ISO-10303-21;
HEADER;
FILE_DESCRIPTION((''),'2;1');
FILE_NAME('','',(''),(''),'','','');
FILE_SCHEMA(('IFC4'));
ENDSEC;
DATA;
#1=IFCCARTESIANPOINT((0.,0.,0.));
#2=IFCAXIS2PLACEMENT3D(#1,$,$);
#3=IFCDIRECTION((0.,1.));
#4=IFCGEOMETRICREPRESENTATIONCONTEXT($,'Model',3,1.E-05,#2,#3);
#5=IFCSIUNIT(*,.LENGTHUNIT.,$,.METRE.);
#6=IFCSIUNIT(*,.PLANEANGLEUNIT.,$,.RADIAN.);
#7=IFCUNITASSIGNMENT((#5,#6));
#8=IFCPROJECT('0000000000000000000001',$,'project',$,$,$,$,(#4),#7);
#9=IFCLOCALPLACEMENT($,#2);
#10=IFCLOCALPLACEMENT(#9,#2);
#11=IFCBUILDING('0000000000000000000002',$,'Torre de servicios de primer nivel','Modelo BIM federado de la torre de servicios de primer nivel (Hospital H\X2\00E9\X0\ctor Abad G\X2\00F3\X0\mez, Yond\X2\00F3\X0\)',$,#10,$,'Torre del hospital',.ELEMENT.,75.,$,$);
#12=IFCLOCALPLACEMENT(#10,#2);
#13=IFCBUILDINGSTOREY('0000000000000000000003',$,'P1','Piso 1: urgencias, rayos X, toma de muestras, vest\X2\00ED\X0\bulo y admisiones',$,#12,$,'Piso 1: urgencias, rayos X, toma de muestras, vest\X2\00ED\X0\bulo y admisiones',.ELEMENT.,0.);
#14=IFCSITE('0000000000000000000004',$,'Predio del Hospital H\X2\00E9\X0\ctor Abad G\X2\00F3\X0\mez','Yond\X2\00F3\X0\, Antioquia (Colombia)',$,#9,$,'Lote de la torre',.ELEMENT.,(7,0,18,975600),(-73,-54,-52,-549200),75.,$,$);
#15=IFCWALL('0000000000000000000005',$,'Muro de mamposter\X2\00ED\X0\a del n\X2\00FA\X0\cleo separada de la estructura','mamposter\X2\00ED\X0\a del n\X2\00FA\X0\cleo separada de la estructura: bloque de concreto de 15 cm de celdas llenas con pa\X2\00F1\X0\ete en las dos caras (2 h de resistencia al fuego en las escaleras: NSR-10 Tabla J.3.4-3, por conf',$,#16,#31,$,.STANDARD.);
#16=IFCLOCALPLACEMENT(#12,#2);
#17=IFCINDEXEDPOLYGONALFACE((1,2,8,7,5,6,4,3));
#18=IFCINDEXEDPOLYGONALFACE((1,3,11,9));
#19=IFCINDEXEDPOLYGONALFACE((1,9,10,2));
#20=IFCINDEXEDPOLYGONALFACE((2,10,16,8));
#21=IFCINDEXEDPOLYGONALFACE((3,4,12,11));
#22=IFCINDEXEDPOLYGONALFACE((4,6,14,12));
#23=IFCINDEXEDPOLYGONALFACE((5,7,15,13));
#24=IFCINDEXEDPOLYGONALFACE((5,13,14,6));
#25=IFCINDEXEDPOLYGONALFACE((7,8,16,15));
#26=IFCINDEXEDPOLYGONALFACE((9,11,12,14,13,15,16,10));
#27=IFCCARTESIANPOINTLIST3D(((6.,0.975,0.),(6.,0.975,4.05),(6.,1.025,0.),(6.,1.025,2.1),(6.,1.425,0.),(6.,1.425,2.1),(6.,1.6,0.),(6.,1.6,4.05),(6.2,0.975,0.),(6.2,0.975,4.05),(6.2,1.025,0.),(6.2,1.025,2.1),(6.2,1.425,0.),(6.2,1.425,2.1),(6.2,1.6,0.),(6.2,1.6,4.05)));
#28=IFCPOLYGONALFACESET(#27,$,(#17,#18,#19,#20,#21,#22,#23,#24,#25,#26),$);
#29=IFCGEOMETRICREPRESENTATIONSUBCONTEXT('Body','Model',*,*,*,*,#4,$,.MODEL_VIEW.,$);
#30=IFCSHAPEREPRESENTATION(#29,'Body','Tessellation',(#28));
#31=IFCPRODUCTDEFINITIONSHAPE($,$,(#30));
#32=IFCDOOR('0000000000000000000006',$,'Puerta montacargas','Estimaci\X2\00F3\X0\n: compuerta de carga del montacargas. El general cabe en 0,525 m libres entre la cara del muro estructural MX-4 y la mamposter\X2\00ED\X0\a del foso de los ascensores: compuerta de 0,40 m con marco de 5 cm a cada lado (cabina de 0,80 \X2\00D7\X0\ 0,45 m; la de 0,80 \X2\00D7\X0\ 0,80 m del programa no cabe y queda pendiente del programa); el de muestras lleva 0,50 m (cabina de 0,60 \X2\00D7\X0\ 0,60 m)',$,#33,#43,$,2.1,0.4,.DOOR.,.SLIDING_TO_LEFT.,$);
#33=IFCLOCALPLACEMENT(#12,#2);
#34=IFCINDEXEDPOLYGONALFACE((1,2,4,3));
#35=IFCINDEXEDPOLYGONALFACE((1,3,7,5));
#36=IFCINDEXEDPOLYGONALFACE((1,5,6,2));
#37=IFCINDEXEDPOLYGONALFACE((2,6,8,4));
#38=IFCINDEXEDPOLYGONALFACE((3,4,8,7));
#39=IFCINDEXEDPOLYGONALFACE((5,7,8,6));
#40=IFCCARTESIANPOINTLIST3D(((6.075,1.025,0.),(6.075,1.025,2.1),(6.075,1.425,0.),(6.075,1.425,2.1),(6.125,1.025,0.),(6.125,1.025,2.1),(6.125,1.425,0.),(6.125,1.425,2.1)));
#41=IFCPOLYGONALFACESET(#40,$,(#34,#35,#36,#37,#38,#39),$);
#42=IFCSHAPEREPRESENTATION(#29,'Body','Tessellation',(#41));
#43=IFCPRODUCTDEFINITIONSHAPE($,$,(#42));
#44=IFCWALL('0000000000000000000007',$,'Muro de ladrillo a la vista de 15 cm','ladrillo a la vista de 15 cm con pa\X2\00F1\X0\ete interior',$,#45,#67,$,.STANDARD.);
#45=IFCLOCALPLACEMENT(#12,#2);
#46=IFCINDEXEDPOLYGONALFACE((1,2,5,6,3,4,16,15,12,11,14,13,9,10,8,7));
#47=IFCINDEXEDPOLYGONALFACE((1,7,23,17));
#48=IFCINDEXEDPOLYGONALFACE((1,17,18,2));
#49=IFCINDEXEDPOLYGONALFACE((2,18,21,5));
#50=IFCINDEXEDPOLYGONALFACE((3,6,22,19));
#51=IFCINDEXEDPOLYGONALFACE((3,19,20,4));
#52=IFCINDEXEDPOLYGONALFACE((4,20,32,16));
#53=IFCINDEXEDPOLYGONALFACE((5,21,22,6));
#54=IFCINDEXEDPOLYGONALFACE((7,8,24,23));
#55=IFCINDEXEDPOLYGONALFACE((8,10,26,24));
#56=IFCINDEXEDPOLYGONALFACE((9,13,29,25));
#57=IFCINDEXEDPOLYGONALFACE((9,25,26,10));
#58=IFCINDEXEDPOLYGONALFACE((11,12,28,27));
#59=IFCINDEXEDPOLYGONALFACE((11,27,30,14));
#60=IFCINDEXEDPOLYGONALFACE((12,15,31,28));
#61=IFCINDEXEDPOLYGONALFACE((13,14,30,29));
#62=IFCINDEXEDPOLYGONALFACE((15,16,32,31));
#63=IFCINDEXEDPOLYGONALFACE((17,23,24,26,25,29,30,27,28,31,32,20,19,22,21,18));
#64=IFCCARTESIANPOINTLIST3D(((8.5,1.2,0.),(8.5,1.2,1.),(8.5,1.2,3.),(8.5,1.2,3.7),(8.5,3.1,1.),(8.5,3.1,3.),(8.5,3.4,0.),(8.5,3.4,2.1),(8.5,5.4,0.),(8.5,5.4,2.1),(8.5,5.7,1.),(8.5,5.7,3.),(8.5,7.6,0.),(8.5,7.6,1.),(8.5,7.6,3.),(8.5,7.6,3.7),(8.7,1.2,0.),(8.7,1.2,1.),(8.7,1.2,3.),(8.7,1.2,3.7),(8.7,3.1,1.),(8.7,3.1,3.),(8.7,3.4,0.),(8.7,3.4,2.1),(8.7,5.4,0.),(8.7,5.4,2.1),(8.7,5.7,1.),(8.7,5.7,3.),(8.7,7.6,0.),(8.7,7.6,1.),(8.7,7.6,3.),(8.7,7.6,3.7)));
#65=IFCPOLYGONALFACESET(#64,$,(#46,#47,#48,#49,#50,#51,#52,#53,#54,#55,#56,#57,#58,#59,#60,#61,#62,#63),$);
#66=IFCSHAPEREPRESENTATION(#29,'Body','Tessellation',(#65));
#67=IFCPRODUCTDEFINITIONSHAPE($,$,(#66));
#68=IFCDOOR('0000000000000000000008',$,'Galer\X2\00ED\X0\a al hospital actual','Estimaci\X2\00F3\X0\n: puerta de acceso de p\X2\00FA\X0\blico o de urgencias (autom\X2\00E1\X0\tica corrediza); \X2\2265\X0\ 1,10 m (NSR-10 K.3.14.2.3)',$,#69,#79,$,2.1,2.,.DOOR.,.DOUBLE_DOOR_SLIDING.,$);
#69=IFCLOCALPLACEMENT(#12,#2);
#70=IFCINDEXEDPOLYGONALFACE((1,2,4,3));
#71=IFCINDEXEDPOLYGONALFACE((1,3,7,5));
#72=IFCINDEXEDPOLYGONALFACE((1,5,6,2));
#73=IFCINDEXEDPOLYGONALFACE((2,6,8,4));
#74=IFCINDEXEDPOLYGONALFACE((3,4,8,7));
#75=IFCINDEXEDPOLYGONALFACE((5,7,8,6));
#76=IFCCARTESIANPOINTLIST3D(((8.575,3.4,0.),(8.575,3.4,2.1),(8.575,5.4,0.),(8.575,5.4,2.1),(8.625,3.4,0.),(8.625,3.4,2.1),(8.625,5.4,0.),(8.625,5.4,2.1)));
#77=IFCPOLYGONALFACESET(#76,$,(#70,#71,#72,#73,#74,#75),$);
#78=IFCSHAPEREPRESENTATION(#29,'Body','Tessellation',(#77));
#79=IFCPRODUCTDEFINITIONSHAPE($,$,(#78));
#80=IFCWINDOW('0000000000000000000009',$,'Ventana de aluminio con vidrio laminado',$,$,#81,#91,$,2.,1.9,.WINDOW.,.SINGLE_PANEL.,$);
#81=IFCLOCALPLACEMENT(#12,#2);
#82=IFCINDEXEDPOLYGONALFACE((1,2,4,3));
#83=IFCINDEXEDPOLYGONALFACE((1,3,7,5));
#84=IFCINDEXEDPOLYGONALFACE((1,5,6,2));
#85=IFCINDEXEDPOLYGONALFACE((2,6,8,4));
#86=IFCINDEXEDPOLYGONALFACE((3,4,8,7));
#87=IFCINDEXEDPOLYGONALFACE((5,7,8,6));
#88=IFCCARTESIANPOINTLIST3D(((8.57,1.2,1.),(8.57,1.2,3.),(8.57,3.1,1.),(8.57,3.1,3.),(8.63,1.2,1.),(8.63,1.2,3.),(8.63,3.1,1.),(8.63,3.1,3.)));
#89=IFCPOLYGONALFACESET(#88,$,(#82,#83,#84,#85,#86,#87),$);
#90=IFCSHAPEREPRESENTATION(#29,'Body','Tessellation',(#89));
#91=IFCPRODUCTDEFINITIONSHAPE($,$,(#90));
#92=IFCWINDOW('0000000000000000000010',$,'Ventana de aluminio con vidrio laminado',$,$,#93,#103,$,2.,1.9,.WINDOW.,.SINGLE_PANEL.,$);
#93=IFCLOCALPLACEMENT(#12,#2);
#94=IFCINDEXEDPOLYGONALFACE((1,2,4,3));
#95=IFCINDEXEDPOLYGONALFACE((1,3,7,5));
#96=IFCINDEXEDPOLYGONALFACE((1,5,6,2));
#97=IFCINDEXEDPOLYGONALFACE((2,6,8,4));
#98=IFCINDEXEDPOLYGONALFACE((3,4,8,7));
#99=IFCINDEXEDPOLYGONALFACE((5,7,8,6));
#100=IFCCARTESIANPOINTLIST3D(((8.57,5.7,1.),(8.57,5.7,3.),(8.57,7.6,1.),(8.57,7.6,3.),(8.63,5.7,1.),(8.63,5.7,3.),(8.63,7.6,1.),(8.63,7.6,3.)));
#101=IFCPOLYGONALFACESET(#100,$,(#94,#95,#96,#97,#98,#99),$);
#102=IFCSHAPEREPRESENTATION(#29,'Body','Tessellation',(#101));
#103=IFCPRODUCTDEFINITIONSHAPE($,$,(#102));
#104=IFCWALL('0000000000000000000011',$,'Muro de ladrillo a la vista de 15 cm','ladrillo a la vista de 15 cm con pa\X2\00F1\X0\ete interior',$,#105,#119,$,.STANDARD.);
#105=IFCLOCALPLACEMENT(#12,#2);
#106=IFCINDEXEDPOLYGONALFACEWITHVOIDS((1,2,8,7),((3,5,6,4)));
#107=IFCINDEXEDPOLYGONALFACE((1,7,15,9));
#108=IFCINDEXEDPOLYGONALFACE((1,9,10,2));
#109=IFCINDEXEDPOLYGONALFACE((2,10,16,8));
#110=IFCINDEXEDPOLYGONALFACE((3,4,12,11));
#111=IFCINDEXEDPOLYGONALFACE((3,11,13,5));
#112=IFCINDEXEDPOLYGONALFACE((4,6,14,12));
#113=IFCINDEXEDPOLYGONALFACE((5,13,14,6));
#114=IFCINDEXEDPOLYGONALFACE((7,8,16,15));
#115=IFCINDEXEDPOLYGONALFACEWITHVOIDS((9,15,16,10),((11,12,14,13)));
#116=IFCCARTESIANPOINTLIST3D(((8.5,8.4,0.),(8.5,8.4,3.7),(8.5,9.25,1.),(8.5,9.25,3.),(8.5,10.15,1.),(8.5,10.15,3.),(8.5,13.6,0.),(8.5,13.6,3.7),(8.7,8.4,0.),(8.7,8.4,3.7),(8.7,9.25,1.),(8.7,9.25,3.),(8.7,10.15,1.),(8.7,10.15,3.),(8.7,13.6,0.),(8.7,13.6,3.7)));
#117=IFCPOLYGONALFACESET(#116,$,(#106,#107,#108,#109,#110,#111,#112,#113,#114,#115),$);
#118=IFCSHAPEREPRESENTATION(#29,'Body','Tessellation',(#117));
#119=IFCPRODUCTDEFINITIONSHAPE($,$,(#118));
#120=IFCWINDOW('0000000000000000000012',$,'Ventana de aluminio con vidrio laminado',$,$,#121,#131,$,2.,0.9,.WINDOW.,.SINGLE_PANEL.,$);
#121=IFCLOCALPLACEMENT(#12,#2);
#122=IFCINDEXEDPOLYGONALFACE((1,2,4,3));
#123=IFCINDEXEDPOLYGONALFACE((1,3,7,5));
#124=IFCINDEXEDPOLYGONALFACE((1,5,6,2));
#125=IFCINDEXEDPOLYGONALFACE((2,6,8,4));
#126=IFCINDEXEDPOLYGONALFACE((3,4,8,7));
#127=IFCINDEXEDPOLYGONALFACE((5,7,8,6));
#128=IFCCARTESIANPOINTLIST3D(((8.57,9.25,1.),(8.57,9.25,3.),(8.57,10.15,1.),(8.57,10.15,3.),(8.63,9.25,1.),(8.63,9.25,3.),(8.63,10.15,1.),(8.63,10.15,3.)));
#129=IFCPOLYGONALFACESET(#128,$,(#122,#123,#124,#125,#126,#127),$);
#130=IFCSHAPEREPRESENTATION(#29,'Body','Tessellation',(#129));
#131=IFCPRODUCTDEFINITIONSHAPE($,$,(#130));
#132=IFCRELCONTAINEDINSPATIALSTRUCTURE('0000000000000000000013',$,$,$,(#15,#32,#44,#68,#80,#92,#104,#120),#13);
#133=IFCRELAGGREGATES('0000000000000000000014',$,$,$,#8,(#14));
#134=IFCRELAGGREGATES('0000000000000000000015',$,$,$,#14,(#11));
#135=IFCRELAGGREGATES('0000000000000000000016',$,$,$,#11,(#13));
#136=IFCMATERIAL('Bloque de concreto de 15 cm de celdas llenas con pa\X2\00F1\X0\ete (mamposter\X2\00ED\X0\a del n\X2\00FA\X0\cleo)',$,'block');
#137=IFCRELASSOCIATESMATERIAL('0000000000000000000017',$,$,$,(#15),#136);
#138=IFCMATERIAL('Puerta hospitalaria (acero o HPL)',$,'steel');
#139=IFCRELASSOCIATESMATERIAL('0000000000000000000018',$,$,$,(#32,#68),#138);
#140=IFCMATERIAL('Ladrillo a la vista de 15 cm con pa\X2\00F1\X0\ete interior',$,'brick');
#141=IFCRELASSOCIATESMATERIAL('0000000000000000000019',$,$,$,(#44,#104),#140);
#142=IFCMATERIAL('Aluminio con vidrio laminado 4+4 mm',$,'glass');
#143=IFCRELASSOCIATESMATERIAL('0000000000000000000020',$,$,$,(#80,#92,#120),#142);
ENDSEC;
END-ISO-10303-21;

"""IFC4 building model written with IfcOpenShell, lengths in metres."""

from ifc_helpers import new_model, si_unit, direction, frame, origin, place, context, subcontext, project, spatial, rectangle, extrude, material, element, fill, save


model = new_model("IFC4")

# Units and contexts
model_context = context("Model", 3, precision=1e-05, world=origin(), true_north=direction((0.0, 1.0)))
body_context = subcontext(model_context, "Body", "Model", "MODEL_VIEW")
ifc_project = project(units=[si_unit("LENGTHUNIT", "METRE"), si_unit("PLANEANGLEUNIT", "RADIAN")], contexts=[model_context])

# Site, building, storey
site_placement = place(None, origin())
site = spatial("IfcSite", under=ifc_project, at=site_placement, Name="Predio del Hospital Héctor Abad Gómez", Description="Yondó, Antioquia (Colombia)", LongName="Lote de la torre", CompositionType="ELEMENT", RefLatitude=(7, 0, 18, 975600), RefLongitude=(-73, -54, -52, -549200), RefElevation=75.0)
building_placement = place(site_placement, origin())
building = spatial("IfcBuilding", under=site, at=building_placement, Name="Torre de servicios de primer nivel", Description="Modelo BIM federado de la torre de servicios de primer nivel (Hospital Héctor Abad Gómez, Yondó)", LongName="Torre del hospital", CompositionType="ELEMENT", ElevationOfRefHeight=75.0)
placement = place(building_placement, origin())
storey = spatial("IfcBuildingStorey", under=building, at=placement, Name="P1", Description="Piso 1: urgencias, rayos X, toma de muestras, vestíbulo y admisiones", LongName="Piso 1: urgencias, rayos X, toma de muestras, vestíbulo y admisiones", CompositionType="ELEMENT", Elevation=0.0)

# Shared definitions
ifc_material_1 = material(Name="Puerta hospitalaria (acero o HPL)", Category="steel")

# Shared definitions
ifc_material_2 = material(Name="Bloque de concreto de 15 cm de celdas llenas con pañete (mampostería del núcleo)", Category="block")

# Wall, opening, door
wall_1 = element("IfcWall", 1, at=placement, inside=storey, material=ifc_material_2, Name="Muro de mampostería del núcleo separada de la estructura", Description="mampostería del núcleo separada de la estructura: bloque de concreto de 15 cm de celdas llenas con pañete en las dos caras (2 h de resistencia al fuego en las escaleras: NSR-10 Tabla J.3.4-3, por conf", PredefinedType="STANDARD", context=body_context, shape_type="SweptSolid", body=[
    extrude(rectangle(XDim=0.2, YDim=0.625), frame((6.1, 1.2875, 0.0)), (0.0, 0.0, 1.0), 4.05),
])
opening_1 = element("IfcOpeningElement", 2, at=placement, cuts=wall_1, PredefinedType="OPENING", context=body_context, shape_type="SweptSolid", body=[
    extrude(rectangle(XDim=0.3, YDim=0.4), frame((6.1, 1.225, 0.0)), (0.0, 0.0, 1.0), 2.1),
])
door_1 = element("IfcDoor", 3, at=placement, inside=storey, material=ifc_material_1, Name="Puerta montacargas", Description="Estimación: compuerta de carga del montacargas. El general cabe en 0,525 m libres entre la cara del muro estructural MX-4 y la mampostería del foso de los ascensores: compuerta de 0,40 m con marco de 5 cm a cada lado (cabina de 0,80 × 0,45 m; la de 0,80 × 0,80 m del programa no cabe y queda pendiente del programa); el de muestras lleva 0,50 m (cabina de 0,60 × 0,60 m)", OperationType="SLIDING_TO_LEFT", OverallHeight=2.1, OverallWidth=0.4, PredefinedType="DOOR", context=body_context, shape_type="SweptSolid", body=[
    extrude(rectangle(XDim=0.05, YDim=0.4), frame((6.1, 1.225, 0.0)), (0.0, 0.0, 1.0), 2.1),
])
fill(opening_1, door_1)

# Wall, openings, door, windows
ifc_material_3 = material(Name="Ladrillo a la vista de 15 cm con pañete interior", Category="brick")
wall_2 = element("IfcWall", 4, at=placement, inside=storey, material=ifc_material_3, Name="Muro de ladrillo a la vista de 15 cm", Description="ladrillo a la vista de 15 cm con pañete interior", PredefinedType="STANDARD", context=body_context, shape_type="SweptSolid", body=[
    extrude(rectangle(XDim=0.2, YDim=6.4), frame((8.6, 4.4, 0.0)), (0.0, 0.0, 1.0), 3.7),
])
opening_2 = element("IfcOpeningElement", 5, at=placement, cuts=wall_2, PredefinedType="OPENING", context=body_context, shape_type="SweptSolid", body=[
    extrude(rectangle(XDim=0.3, YDim=2.0), frame((8.6, 4.4, 0.0)), (0.0, 0.0, 1.0), 2.1),
])
opening_3 = element("IfcOpeningElement", 6, at=placement, cuts=wall_2, PredefinedType="OPENING", context=body_context, shape_type="SweptSolid", body=[
    extrude(rectangle(XDim=0.3, YDim=1.9), frame((8.6, 2.15, 1.0)), (0.0, 0.0, 1.0), 2.0),
])
opening_4 = element("IfcOpeningElement", 7, at=placement, cuts=wall_2, PredefinedType="OPENING", context=body_context, shape_type="SweptSolid", body=[
    extrude(rectangle(XDim=0.3, YDim=1.9), frame((8.6, 6.65, 1.0)), (0.0, 0.0, 1.0), 2.0),
])
door_2 = element("IfcDoor", 8, at=placement, inside=storey, material=ifc_material_1, Name="Galería al hospital actual", Description="Estimación: puerta de acceso de público o de urgencias (automática corrediza); ≥ 1,10 m (NSR-10 K.3.14.2.3)", OperationType="DOUBLE_DOOR_SLIDING", OverallHeight=2.1, OverallWidth=2.0, PredefinedType="DOOR", context=body_context, shape_type="SweptSolid", body=[
    extrude(rectangle(XDim=0.05, YDim=2.0), frame((8.6, 4.4, 0.0)), (0.0, 0.0, 1.0), 2.1),
])
fill(opening_2, door_2)
ifc_material_4 = material(Name="Aluminio con vidrio laminado 4+4 mm", Category="glass")
window_1 = element("IfcWindow", 9, at=placement, inside=storey, material=ifc_material_4, Name="Ventana de aluminio con vidrio laminado", OverallHeight=2.0, OverallWidth=1.9, PartitioningType="SINGLE_PANEL", PredefinedType="WINDOW", context=body_context, shape_type="SweptSolid", body=[
    extrude(rectangle(XDim=0.06, YDim=1.9), frame((8.6, 2.15, 1.0)), (0.0, 0.0, 1.0), 2.0),
])
fill(opening_3, window_1)
window_2 = element("IfcWindow", 10, at=placement, inside=storey, material=ifc_material_4, Name="Ventana de aluminio con vidrio laminado", OverallHeight=2.0, OverallWidth=1.9, PartitioningType="SINGLE_PANEL", PredefinedType="WINDOW", context=body_context, shape_type="SweptSolid", body=[
    extrude(rectangle(XDim=0.06, YDim=1.9), frame((8.6, 6.65, 1.0)), (0.0, 0.0, 1.0), 2.0),
])
fill(opening_4, window_2)

# Wall, opening, window
wall_3 = element("IfcWall", 11, at=placement, inside=storey, material=ifc_material_3, Name="Muro de ladrillo a la vista de 15 cm", Description="ladrillo a la vista de 15 cm con pañete interior", PredefinedType="STANDARD", context=body_context, shape_type="SweptSolid", body=[
    extrude(rectangle(XDim=0.2, YDim=5.2), frame((8.6, 11.0, 0.0)), (0.0, 0.0, 1.0), 3.7),
])
opening_5 = element("IfcOpeningElement", 12, at=placement, cuts=wall_3, PredefinedType="OPENING", context=body_context, shape_type="SweptSolid", body=[
    extrude(rectangle(XDim=0.3, YDim=0.9), frame((8.6, 9.7, 1.0)), (0.0, 0.0, 1.0), 2.0),
])
window_3 = element("IfcWindow", 13, at=placement, inside=storey, material=ifc_material_4, Name="Ventana de aluminio con vidrio laminado", OverallHeight=2.0, OverallWidth=0.9, PartitioningType="SINGLE_PANEL", PredefinedType="WINDOW", context=body_context, shape_type="SweptSolid", body=[
    extrude(rectangle(XDim=0.06, YDim=0.9), frame((8.6, 9.7, 1.0)), (0.0, 0.0, 1.0), 2.0),
])
fill(opening_5, window_3)

save(model, "model.ifc")
